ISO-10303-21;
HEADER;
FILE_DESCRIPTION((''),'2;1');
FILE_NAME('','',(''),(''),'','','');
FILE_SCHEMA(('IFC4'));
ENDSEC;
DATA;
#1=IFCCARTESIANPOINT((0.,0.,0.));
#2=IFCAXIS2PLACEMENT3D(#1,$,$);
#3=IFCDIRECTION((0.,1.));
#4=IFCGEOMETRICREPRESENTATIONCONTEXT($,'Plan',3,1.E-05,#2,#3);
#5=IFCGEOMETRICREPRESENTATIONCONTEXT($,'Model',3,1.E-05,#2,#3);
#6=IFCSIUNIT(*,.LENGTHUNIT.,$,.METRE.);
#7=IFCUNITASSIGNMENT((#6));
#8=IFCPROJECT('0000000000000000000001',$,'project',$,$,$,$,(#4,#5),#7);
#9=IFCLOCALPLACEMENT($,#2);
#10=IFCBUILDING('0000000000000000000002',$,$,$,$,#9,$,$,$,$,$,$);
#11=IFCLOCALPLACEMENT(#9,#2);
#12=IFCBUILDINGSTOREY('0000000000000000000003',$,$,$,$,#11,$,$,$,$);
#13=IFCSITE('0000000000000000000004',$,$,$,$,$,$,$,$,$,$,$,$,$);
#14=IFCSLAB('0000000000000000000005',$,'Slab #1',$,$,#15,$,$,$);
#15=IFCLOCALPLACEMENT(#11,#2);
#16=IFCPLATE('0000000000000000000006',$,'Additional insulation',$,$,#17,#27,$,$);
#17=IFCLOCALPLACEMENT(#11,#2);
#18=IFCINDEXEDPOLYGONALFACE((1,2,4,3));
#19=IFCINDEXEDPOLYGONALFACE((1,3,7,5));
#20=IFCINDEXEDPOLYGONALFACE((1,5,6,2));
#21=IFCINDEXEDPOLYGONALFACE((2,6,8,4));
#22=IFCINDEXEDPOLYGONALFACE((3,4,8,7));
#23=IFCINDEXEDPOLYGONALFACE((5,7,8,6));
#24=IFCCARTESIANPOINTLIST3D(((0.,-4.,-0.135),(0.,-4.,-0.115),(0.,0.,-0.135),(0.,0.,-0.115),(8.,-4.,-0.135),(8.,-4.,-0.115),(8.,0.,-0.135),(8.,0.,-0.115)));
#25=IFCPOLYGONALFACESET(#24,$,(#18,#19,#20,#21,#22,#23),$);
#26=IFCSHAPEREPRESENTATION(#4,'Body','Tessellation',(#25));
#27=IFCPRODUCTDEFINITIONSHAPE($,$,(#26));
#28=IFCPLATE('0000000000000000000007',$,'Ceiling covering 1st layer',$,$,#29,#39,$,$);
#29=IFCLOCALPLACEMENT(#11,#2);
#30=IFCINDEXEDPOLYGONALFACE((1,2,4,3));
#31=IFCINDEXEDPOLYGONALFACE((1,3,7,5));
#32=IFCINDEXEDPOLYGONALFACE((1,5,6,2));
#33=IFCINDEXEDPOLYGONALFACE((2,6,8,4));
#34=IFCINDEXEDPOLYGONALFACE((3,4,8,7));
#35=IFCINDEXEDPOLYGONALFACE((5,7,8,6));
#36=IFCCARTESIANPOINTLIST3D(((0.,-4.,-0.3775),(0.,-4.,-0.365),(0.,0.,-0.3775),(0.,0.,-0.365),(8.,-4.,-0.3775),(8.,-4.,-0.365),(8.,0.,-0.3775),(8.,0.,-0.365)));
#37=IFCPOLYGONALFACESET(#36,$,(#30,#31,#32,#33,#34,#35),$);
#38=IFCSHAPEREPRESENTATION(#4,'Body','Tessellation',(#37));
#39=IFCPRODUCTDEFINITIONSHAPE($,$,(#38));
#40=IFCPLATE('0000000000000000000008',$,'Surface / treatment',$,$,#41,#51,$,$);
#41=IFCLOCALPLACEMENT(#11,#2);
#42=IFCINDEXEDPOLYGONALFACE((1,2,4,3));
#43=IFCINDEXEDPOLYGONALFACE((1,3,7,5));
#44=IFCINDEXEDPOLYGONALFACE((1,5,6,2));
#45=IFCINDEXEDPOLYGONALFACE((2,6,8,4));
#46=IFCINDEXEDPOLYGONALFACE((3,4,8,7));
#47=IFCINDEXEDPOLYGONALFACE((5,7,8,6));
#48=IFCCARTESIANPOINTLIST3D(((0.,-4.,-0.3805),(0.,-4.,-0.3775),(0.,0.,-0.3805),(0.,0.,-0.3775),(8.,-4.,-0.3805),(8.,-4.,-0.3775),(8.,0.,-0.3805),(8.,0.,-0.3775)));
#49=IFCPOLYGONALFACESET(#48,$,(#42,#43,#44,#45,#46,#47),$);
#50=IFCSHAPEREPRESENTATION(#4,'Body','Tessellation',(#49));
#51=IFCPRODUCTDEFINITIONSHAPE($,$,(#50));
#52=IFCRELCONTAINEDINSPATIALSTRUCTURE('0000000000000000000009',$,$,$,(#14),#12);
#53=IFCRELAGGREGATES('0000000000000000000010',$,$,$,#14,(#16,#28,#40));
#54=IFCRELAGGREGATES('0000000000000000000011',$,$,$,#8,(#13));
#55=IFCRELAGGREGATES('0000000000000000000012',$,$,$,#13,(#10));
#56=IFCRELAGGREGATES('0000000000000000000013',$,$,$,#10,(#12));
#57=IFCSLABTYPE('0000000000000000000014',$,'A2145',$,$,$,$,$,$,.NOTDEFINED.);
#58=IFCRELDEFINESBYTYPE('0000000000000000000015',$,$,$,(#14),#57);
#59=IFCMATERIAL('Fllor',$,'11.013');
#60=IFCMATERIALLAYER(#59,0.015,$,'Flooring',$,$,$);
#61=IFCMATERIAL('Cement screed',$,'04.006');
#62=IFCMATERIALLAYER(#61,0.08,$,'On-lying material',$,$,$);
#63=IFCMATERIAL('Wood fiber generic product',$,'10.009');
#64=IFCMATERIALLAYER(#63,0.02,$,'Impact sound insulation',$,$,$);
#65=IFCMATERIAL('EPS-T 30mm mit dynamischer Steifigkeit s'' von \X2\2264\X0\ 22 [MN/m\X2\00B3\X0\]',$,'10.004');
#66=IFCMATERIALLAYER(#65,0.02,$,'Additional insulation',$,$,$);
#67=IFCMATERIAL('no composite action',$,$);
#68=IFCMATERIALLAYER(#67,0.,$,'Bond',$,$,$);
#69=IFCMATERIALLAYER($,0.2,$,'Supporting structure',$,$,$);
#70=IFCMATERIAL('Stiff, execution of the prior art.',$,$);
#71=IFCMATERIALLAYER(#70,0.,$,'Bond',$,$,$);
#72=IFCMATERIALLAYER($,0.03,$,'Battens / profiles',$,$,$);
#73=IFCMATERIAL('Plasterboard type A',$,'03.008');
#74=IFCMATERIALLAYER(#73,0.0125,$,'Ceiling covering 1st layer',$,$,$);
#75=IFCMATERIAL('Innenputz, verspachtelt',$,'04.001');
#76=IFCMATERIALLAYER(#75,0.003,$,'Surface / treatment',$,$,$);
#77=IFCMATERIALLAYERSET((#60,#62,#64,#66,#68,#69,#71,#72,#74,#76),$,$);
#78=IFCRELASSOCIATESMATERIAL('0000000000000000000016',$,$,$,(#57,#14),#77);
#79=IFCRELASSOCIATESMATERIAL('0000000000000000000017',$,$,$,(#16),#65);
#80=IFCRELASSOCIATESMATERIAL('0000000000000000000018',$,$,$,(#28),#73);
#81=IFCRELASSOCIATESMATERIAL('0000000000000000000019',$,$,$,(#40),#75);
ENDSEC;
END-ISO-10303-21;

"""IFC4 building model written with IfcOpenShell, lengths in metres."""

from ifc_helpers import new_model, si_unit, direction, frame, frame_2d, origin, place, context, project, spatial, rectangle, extrude, material, layer, layer_set, type_object, element, aggregate, save


model = new_model("IFC4")

# Units and contexts
plan_context = context("Plan", 3, precision=1e-05, world=origin(), true_north=direction((0.0, 1.0)))
model_context = context("Model", 3, precision=1e-05, world=origin(), true_north=direction((0.0, 1.0)))
ifc_project = project(units=[si_unit("LENGTHUNIT", "METRE")], contexts=[plan_context, model_context])

# Site, building, storey
site = spatial("IfcSite", under=ifc_project)
building_placement = place(None, origin())
building = spatial("IfcBuilding", under=site, at=building_placement)
storey_placement = place(building_placement, origin())
storey = spatial("IfcBuildingStorey", under=building, at=storey_placement)

# Slab, plates
ifc_material_1 = material(Name="Fllor", Category="11.013")
ifc_layer_1 = layer(ifc_material_1, 0.015, Name="Flooring")
ifc_material_2 = material(Name="Cement screed", Category="04.006")
ifc_layer_2 = layer(ifc_material_2, 0.08, Name="On-lying material")
ifc_material_3 = material(Name="Wood fiber generic product", Category="10.009")
ifc_layer_3 = layer(ifc_material_3, 0.02, Name="Impact sound insulation")
ifc_material_4 = material(Name="EPS-T 30mm mit dynamischer Steifigkeit s' von ≤ 22 [MN/m³]", Category="10.004")
ifc_layer_4 = layer(ifc_material_4, 0.02, Name="Additional insulation")
ifc_material_5 = material(Name="no composite action")
ifc_layer_5 = layer(ifc_material_5, 0.0, Name="Bond")
ifc_layer_6 = layer(None, 0.2, Name="Supporting structure")
ifc_material_6 = material(Name="Stiff, execution of the prior art.")
ifc_layer_7 = layer(ifc_material_6, 0.0, Name="Bond")
ifc_layer_8 = layer(None, 0.03, Name="Battens / profiles")
ifc_material_7 = material(Name="Plasterboard type A", Category="03.008")
ifc_layer_9 = layer(ifc_material_7, 0.0125, Name="Ceiling covering 1st layer")
ifc_material_8 = material(Name="Innenputz, verspachtelt", Category="04.001")
ifc_layer_10 = layer(ifc_material_8, 0.003, Name="Surface / treatment")
ifc_layer_set = layer_set([ifc_layer_1, ifc_layer_2, ifc_layer_3, ifc_layer_4, ifc_layer_5, ifc_layer_6, ifc_layer_7, ifc_layer_8, ifc_layer_9, ifc_layer_10])
slab_type = type_object("IfcSlabType", Name="A2145", PredefinedType="NOTDEFINED", material=ifc_layer_set)
slab_placement = place(None, frame((0.0, 0.0, 0.0), z_axis=(0.0, 0.0, -1.0), x_axis=(1.0, 0.0, 0.0)))
slab = element("IfcSlab", 1, at=slab_placement, inside=storey, type_object=slab_type, material=ifc_layer_set, Name="Slab #1")
plate_1_placement = place(slab_placement, origin())
plate_1 = element("IfcPlate", 2, at=plate_1_placement, material=ifc_material_4, Name="Additional insulation", context=plan_context, shape_type="SweptSolid", body=[
    extrude(rectangle(XDim=8.0, YDim=4.0, at=frame_2d((4.0, 2.0), x_axis=(1.0, 0.0))), frame((0.0, 0.0, 0.115), z_axis=(0.0, 0.0, 1.0), x_axis=(1.0, 0.0, 0.0)), (0.0, 0.0, 1.0), 0.02),
])
plate_2_placement = place(slab_placement, origin())
plate_2 = element("IfcPlate", 3, at=plate_2_placement, material=ifc_material_7, Name="Ceiling covering 1st layer", context=plan_context, shape_type="SweptSolid", body=[
    extrude(rectangle(XDim=8.0, YDim=4.0, at=frame_2d((4.0, 2.0), x_axis=(1.0, 0.0))), frame((0.0, 0.0, 0.365), z_axis=(0.0, 0.0, 1.0), x_axis=(1.0, 0.0, 0.0)), (0.0, 0.0, 1.0), 0.0125),
])
plate_3_placement = place(slab_placement, origin())
plate_3 = element("IfcPlate", 4, at=plate_3_placement, material=ifc_material_8, Name="Surface / treatment", context=plan_context, shape_type="SweptSolid", body=[
    extrude(rectangle(XDim=8.0, YDim=4.0, at=frame_2d((4.0, 2.0), x_axis=(1.0, 0.0))), frame((0.0, 0.0, 0.3775), z_axis=(0.0, 0.0, 1.0), x_axis=(1.0, 0.0, 0.0)), (0.0, 0.0, 1.0), 0.003),
])
aggregate(slab, [plate_1, plate_2, plate_3])

save(model, "model.ifc")
